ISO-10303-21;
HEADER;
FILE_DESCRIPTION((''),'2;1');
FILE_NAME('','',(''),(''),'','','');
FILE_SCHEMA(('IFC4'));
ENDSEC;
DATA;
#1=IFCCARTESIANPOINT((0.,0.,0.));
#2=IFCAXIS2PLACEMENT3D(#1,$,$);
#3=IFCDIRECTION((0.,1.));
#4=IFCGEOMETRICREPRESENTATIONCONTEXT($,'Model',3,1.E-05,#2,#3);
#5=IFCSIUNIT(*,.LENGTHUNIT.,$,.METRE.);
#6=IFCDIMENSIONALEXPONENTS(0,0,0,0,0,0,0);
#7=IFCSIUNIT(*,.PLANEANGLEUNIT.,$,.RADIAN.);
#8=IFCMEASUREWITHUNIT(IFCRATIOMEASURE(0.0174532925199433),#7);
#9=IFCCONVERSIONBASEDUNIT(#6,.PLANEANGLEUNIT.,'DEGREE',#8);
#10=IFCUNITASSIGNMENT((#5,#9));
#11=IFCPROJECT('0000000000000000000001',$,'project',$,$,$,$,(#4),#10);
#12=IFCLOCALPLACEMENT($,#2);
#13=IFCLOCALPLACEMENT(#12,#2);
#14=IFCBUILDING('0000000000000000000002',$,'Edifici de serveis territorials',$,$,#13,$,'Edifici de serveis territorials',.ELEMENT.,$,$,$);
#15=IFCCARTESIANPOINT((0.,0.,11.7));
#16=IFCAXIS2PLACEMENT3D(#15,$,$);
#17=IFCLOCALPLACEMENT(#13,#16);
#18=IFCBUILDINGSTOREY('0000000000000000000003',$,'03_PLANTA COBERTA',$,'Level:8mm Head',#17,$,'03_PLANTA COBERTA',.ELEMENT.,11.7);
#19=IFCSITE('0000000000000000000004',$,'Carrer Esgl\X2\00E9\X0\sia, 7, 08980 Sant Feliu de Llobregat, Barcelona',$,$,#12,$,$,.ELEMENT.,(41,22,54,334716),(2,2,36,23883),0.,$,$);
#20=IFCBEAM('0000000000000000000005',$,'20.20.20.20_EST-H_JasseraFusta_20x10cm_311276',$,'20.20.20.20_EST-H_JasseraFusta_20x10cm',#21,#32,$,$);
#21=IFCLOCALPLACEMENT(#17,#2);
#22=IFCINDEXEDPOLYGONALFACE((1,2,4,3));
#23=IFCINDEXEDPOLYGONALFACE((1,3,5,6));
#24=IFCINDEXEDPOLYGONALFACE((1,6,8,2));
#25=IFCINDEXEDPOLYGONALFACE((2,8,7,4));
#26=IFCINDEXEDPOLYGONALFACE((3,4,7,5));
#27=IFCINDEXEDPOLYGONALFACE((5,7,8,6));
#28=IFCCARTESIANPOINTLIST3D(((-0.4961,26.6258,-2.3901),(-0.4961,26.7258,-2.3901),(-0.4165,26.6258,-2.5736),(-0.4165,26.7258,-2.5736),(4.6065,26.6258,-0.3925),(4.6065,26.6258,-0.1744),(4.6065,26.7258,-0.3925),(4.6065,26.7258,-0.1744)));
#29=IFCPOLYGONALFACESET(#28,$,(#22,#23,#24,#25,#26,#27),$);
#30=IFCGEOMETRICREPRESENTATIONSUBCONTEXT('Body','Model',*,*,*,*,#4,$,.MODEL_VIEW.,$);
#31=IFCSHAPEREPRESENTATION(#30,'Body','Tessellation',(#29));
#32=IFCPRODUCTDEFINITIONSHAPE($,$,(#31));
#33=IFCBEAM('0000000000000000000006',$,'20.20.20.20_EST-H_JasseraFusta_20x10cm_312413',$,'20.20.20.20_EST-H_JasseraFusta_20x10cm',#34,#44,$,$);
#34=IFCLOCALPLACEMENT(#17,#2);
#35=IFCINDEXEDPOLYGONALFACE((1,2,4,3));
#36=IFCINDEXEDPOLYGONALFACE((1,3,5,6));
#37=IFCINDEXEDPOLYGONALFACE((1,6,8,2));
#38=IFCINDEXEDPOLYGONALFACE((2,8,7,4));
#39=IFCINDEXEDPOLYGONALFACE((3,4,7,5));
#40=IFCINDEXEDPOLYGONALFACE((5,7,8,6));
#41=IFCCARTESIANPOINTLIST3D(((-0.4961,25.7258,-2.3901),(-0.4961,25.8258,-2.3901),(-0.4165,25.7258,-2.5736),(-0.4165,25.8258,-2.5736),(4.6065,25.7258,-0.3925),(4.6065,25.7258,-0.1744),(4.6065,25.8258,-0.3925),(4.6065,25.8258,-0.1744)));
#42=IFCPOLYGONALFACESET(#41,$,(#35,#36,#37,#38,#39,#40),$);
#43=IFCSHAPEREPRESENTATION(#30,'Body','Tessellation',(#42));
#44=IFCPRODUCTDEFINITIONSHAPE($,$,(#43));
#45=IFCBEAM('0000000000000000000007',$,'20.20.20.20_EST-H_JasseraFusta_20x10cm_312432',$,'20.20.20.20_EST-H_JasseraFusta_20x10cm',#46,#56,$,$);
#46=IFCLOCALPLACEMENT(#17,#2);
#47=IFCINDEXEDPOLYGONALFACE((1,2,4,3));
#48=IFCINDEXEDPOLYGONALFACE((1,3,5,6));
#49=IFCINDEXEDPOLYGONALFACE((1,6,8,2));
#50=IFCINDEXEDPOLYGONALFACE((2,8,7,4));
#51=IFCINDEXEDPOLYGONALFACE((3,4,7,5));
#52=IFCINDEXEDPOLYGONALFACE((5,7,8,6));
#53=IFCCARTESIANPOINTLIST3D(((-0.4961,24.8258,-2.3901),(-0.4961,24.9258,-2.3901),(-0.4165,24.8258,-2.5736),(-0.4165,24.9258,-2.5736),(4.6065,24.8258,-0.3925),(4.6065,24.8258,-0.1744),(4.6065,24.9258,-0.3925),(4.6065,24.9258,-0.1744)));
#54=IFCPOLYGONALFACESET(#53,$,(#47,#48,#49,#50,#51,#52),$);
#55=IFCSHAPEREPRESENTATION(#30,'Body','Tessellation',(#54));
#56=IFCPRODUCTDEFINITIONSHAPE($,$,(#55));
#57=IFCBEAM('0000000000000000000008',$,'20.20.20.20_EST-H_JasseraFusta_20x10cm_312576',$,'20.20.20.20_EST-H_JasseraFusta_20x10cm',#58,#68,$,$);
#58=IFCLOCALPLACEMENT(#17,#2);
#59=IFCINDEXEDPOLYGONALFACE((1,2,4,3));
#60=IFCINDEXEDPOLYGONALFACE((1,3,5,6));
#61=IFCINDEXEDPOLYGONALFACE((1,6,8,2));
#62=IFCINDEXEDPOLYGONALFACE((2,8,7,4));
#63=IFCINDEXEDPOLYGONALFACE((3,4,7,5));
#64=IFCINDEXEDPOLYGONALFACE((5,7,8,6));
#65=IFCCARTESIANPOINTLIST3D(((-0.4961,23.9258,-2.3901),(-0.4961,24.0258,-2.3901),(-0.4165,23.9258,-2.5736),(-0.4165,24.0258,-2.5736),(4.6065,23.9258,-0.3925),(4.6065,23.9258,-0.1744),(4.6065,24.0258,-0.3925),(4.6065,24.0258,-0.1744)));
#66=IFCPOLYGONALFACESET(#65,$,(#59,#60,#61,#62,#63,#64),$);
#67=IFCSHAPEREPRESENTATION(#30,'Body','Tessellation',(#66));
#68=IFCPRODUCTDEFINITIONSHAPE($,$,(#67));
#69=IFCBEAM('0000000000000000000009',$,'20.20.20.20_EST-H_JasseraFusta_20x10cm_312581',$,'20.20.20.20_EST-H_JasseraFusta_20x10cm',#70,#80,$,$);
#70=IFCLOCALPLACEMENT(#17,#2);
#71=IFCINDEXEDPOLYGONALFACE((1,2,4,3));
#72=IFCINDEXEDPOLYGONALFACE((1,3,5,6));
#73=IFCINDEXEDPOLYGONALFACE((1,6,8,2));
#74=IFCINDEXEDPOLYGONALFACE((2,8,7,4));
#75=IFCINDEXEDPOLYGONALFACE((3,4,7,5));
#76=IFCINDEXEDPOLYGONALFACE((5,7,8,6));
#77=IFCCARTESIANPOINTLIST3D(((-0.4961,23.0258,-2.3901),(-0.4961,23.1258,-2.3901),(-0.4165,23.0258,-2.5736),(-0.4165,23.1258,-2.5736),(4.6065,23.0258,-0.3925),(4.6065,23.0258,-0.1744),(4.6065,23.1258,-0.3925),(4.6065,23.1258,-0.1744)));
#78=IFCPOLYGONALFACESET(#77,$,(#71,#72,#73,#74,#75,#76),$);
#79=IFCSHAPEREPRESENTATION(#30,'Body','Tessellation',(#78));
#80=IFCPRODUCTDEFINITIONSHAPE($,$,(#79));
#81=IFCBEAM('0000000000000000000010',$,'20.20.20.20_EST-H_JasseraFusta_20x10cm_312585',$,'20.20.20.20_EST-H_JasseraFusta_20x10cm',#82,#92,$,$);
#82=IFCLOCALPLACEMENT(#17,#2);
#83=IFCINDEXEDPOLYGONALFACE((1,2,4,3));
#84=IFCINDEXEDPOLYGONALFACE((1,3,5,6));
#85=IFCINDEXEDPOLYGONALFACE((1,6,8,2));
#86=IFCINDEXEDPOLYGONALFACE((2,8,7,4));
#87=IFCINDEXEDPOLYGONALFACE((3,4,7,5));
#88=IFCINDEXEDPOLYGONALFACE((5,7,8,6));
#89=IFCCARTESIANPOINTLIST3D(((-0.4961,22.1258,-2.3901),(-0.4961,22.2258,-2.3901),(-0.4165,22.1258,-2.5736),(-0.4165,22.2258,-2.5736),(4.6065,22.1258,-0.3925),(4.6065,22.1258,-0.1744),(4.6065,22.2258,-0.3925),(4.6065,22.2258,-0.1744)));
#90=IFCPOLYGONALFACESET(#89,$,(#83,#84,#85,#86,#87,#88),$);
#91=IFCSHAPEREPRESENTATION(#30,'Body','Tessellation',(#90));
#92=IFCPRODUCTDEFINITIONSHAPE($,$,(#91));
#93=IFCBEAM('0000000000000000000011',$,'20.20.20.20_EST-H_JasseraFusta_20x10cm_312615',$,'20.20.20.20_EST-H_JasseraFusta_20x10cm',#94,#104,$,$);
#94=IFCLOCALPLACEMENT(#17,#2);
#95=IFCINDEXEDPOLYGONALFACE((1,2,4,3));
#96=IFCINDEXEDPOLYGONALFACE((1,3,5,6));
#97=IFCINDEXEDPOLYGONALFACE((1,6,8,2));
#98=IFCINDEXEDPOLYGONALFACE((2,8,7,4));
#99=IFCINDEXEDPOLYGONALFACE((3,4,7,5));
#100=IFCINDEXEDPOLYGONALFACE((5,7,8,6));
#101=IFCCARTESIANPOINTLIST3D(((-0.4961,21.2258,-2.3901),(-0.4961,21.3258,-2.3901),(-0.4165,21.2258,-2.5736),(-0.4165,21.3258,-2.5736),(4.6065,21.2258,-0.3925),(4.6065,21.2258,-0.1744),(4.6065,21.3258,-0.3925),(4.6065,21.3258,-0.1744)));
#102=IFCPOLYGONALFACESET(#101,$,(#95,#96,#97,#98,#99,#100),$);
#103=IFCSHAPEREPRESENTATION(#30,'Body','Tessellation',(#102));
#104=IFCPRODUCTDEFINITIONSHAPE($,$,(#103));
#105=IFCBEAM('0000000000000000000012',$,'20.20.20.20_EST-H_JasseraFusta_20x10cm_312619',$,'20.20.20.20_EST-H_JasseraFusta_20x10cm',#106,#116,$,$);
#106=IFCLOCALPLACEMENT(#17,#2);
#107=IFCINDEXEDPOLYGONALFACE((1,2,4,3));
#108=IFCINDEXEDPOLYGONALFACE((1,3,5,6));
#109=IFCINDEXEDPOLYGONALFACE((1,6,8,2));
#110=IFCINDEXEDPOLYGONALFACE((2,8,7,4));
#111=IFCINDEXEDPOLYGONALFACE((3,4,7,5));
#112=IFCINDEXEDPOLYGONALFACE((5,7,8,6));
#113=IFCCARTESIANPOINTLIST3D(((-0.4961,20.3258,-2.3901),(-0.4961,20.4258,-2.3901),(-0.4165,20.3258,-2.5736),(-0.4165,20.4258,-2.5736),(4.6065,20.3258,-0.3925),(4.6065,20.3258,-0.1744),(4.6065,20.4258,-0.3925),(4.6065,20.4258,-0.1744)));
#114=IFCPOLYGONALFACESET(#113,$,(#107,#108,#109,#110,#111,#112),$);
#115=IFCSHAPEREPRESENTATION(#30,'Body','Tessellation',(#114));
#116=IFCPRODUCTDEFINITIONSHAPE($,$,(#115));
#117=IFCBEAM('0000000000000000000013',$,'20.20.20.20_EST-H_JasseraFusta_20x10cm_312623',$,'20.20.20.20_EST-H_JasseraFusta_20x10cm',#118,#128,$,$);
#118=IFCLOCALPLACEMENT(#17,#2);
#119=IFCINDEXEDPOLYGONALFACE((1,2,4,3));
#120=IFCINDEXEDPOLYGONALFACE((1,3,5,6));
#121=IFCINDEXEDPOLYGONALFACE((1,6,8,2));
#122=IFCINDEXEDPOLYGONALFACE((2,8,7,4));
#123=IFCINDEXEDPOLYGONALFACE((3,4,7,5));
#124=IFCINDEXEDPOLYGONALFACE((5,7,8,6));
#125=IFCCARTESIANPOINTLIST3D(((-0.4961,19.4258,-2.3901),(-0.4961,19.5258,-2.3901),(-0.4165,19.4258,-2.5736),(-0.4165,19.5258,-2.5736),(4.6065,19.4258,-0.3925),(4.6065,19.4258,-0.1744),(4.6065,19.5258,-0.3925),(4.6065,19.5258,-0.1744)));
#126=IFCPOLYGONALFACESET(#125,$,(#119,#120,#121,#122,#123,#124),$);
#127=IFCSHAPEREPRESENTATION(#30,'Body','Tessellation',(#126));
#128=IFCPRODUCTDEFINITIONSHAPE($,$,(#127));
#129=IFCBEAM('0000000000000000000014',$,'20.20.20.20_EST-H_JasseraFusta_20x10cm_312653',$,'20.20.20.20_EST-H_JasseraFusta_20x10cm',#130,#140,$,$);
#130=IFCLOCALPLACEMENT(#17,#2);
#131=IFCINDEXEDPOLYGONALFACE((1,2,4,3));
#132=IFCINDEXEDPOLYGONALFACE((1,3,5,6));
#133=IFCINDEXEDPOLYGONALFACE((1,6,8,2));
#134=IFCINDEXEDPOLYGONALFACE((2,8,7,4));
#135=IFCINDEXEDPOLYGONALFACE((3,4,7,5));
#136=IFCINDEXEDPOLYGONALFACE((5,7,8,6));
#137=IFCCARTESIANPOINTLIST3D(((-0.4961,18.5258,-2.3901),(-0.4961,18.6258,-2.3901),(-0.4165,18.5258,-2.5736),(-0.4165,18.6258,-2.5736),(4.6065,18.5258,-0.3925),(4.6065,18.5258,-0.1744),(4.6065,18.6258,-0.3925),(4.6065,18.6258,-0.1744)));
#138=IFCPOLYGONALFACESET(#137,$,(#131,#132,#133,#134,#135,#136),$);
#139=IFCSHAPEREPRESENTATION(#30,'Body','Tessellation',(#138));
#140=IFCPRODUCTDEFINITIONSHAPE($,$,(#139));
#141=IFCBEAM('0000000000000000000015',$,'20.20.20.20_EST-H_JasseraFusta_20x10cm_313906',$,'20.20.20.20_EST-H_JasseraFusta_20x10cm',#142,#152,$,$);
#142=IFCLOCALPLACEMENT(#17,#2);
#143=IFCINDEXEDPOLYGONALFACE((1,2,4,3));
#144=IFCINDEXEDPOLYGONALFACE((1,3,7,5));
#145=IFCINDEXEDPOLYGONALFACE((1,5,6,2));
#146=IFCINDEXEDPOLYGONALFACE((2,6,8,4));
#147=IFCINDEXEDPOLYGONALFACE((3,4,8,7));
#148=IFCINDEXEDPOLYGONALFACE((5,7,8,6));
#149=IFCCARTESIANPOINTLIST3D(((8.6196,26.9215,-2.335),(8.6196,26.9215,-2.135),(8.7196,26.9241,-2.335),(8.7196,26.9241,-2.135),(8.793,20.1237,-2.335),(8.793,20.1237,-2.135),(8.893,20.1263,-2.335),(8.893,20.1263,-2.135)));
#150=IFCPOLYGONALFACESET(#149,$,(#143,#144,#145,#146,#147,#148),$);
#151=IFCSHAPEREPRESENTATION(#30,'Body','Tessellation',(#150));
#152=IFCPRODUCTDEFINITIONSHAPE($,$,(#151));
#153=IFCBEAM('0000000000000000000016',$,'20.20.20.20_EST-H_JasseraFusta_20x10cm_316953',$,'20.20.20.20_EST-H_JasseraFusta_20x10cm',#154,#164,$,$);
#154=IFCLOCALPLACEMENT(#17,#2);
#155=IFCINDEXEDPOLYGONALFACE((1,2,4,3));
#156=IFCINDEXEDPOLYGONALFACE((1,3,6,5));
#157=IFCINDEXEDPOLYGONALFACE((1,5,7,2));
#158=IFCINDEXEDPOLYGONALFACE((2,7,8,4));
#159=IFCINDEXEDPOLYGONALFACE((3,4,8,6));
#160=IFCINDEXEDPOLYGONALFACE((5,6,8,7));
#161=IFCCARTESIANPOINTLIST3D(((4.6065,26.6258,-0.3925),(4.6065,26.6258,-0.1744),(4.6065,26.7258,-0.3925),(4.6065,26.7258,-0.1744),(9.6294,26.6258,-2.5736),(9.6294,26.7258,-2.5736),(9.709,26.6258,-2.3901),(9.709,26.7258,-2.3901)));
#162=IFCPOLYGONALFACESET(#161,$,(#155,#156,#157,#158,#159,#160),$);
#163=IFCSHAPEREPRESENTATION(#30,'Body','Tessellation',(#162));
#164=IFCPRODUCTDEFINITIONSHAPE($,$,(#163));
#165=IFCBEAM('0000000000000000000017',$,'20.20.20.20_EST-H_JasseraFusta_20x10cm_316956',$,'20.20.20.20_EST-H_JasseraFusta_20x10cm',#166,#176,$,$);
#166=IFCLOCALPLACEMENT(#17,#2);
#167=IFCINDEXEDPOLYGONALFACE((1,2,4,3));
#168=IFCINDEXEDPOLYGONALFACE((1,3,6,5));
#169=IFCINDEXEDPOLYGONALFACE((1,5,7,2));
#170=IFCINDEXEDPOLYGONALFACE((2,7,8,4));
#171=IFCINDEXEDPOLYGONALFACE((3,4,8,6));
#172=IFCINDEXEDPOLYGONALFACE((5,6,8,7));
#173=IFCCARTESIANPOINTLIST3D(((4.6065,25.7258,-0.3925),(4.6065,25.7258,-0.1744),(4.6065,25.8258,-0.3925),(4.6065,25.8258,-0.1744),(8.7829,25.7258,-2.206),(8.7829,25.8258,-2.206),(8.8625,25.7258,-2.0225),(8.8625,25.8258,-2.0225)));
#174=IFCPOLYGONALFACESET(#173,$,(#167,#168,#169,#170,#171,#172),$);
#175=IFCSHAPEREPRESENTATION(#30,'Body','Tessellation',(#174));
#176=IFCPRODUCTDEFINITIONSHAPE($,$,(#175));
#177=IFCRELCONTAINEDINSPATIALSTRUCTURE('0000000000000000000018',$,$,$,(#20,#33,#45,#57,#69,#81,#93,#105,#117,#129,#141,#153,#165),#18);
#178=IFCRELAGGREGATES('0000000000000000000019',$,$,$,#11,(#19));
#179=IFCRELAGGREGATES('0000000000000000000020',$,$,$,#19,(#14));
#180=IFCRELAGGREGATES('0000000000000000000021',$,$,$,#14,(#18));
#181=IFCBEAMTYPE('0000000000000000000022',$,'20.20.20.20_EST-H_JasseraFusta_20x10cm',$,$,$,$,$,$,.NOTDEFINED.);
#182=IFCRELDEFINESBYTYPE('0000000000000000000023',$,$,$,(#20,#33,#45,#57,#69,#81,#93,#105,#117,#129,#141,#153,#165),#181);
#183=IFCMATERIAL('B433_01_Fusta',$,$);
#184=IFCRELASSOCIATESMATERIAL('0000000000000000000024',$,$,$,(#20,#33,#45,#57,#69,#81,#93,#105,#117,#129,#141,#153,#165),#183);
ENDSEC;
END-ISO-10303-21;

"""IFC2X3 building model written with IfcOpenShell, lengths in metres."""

from ifc_helpers import new_model, entity, si_unit, converted_unit, direction, frame, frame_2d, origin, origin_2d_with_axis, place, context, subcontext, project, spatial, rectangle, extrude, clip, halfspace, material, type_object, element, save


model = new_model("IFC2X3")

# Units and contexts
model_context = context("Model", 3, precision=1e-05, world=origin(), true_north=direction((0.0, 1.0)))
body_context = subcontext(model_context, "Body", "Model", "MODEL_VIEW")
ifc_project = project(units=[si_unit("LENGTHUNIT", "METRE"), converted_unit("PLANEANGLEUNIT", "DEGREE", entity("IfcRatioMeasure", 0.0174532925199433), si_unit("PLANEANGLEUNIT", "RADIAN"), dimensions=[0, 0, 0, 0, 0, 0, 0])], contexts=[model_context])

# Site, building, storey
site_placement = place(None, origin())
site = spatial("IfcSite", under=ifc_project, at=site_placement, Name="Carrer Església, 7, 08980 Sant Feliu de Llobregat, Barcelona", CompositionType="ELEMENT", RefLatitude=(41, 22, 54, 334716), RefLongitude=(2, 2, 36, 23883), RefElevation=0.0)
building_placement = place(site_placement, origin())
building = spatial("IfcBuilding", under=site, at=building_placement, Name="Edifici de serveis territorials", LongName="Edifici de serveis territorials", CompositionType="ELEMENT")
storey_placement = place(building_placement, frame((0.0, 0.0, 11.7)))
storey = spatial("IfcBuildingStorey", under=building, at=storey_placement, Name="03_PLANTA COBERTA", ObjectType="Level:8mm Head", LongName="03_PLANTA COBERTA", CompositionType="ELEMENT", Elevation=11.7)

# Beams
ifc_material_1 = material(Name="B433_01_Fusta")
beam_type = type_object("IfcBeamType", Name="20.20.20.20_EST-H_JasseraFusta_20x10cm", PredefinedType="NOTDEFINED")
beam_1_placement = place(storey_placement, frame((4.6065, 26.6758, -0.1744), z_axis=(-0.3983, 0.0, 0.917255), x_axis=(-0.917255, 0.0, -0.3983)))
element("IfcBeam", 1, at=beam_1_placement, inside=storey, type_object=beam_type, material=ifc_material_1, Name="20.20.20.20_EST-H_JasseraFusta_20x10cm_311276", ObjectType="20.20.20.20_EST-H_JasseraFusta_20x10cm", context=body_context, shape_type="Clipping", body=[
    clip(extrude(rectangle(XDim=0.2, YDim=0.1, at=frame_2d((0.0, 0.0), x_axis=(1.0, 0.0))), frame((0.0, 0.0, -0.1), z_axis=(1.0, 0.0, 0.0), x_axis=(0.0, 0.0, -1.0)), (0.0, 0.0, 1.0), 5.5629), halfspace(frame((0.0868, 0.0, -0.2), z_axis=(-0.917255, 0.0, -0.3983), x_axis=(0.0, 1.0, 0.0)), False)),
])
beam_2_placement = place(storey_placement, frame((4.6065, 25.7758, -0.1744), z_axis=(-0.3983, 0.0, 0.917255), x_axis=(-0.917255, 0.0, -0.3983)))
element("IfcBeam", 2, at=beam_2_placement, inside=storey, type_object=beam_type, material=ifc_material_1, Name="20.20.20.20_EST-H_JasseraFusta_20x10cm_312413", ObjectType="20.20.20.20_EST-H_JasseraFusta_20x10cm", context=body_context, shape_type="Clipping", body=[
    clip(extrude(rectangle(XDim=0.2, YDim=0.1, at=frame_2d((0.0, 0.0), x_axis=(1.0, 0.0))), frame((0.0, 0.0, -0.1), z_axis=(1.0, 0.0, 0.0), x_axis=(0.0, 0.0, -1.0)), (0.0, 0.0, 1.0), 5.5629), halfspace(frame((0.0868, 0.0, -0.2), z_axis=(-0.917255, 0.0, -0.3983), x_axis=(0.0, 1.0, 0.0)), False)),
])
beam_3_placement = place(storey_placement, frame((4.6065, 24.8758, -0.1744), z_axis=(-0.3983, 0.0, 0.917255), x_axis=(-0.917255, 0.0, -0.3983)))
element("IfcBeam", 3, at=beam_3_placement, inside=storey, type_object=beam_type, material=ifc_material_1, Name="20.20.20.20_EST-H_JasseraFusta_20x10cm_312432", ObjectType="20.20.20.20_EST-H_JasseraFusta_20x10cm", context=body_context, shape_type="Clipping", body=[
    clip(extrude(rectangle(XDim=0.2, YDim=0.1, at=frame_2d((0.0, 0.0), x_axis=(1.0, 0.0))), frame((0.0, 0.0, -0.1), z_axis=(1.0, 0.0, 0.0), x_axis=(0.0, 0.0, -1.0)), (0.0, 0.0, 1.0), 5.5629), halfspace(frame((0.0868, 0.0, -0.2), z_axis=(-0.917255, 0.0, -0.3983), x_axis=(0.0, 1.0, 0.0)), False)),
])
beam_4_placement = place(storey_placement, frame((4.6065, 23.9758, -0.1744), z_axis=(-0.3983, 0.0, 0.917255), x_axis=(-0.917255, 0.0, -0.3983)))
element("IfcBeam", 4, at=beam_4_placement, inside=storey, type_object=beam_type, material=ifc_material_1, Name="20.20.20.20_EST-H_JasseraFusta_20x10cm_312576", ObjectType="20.20.20.20_EST-H_JasseraFusta_20x10cm", context=body_context, shape_type="Clipping", body=[
    clip(extrude(rectangle(XDim=0.2, YDim=0.1, at=frame_2d((0.0, 0.0), x_axis=(1.0, 0.0))), frame((0.0, 0.0, -0.1), z_axis=(1.0, 0.0, 0.0), x_axis=(0.0, 0.0, -1.0)), (0.0, 0.0, 1.0), 5.5629), halfspace(frame((0.0868, 0.0, -0.2), z_axis=(-0.917255, 0.0, -0.3983), x_axis=(0.0, 1.0, 0.0)), False)),
])
beam_5_placement = place(storey_placement, frame((4.6065, 23.0758, -0.1744), z_axis=(-0.3983, 0.0, 0.917255), x_axis=(-0.917255, 0.0, -0.3983)))
element("IfcBeam", 5, at=beam_5_placement, inside=storey, type_object=beam_type, material=ifc_material_1, Name="20.20.20.20_EST-H_JasseraFusta_20x10cm_312581", ObjectType="20.20.20.20_EST-H_JasseraFusta_20x10cm", context=body_context, shape_type="Clipping", body=[
    clip(extrude(rectangle(XDim=0.2, YDim=0.1, at=frame_2d((0.0, 0.0), x_axis=(1.0, 0.0))), frame((0.0, 0.0, -0.1), z_axis=(1.0, 0.0, 0.0), x_axis=(0.0, 0.0, -1.0)), (0.0, 0.0, 1.0), 5.5629), halfspace(frame((0.0868, 0.0, -0.2), z_axis=(-0.917255, 0.0, -0.3983), x_axis=(0.0, 1.0, 0.0)), False)),
])
beam_6_placement = place(storey_placement, frame((4.6065, 22.1758, -0.1744), z_axis=(-0.3983, 0.0, 0.917255), x_axis=(-0.917255, 0.0, -0.3983)))
element("IfcBeam", 6, at=beam_6_placement, inside=storey, type_object=beam_type, material=ifc_material_1, Name="20.20.20.20_EST-H_JasseraFusta_20x10cm_312585", ObjectType="20.20.20.20_EST-H_JasseraFusta_20x10cm", context=body_context, shape_type="Clipping", body=[
    clip(extrude(rectangle(XDim=0.2, YDim=0.1, at=frame_2d((0.0, 0.0), x_axis=(1.0, 0.0))), frame((0.0, 0.0, -0.1), z_axis=(1.0, 0.0, 0.0), x_axis=(0.0, 0.0, -1.0)), (0.0, 0.0, 1.0), 5.5629), halfspace(frame((0.0868, 0.0, -0.2), z_axis=(-0.917255, 0.0, -0.3983), x_axis=(0.0, 1.0, 0.0)), False)),
])
beam_7_placement = place(storey_placement, frame((4.6065, 21.2758, -0.1744), z_axis=(-0.3983, 0.0, 0.917255), x_axis=(-0.917255, 0.0, -0.3983)))
element("IfcBeam", 7, at=beam_7_placement, inside=storey, type_object=beam_type, material=ifc_material_1, Name="20.20.20.20_EST-H_JasseraFusta_20x10cm_312615", ObjectType="20.20.20.20_EST-H_JasseraFusta_20x10cm", context=body_context, shape_type="Clipping", body=[
    clip(extrude(rectangle(XDim=0.2, YDim=0.1, at=frame_2d((0.0, 0.0), x_axis=(1.0, 0.0))), frame((0.0, 0.0, -0.1), z_axis=(1.0, 0.0, 0.0), x_axis=(0.0, 0.0, -1.0)), (0.0, 0.0, 1.0), 5.5629), halfspace(frame((0.0868, 0.0, -0.2), z_axis=(-0.917255, 0.0, -0.3983), x_axis=(0.0, 1.0, 0.0)), False)),
])
beam_8_placement = place(storey_placement, frame((4.6065, 20.3758, -0.1744), z_axis=(-0.3983, 0.0, 0.917255), x_axis=(-0.917255, 0.0, -0.3983)))
element("IfcBeam", 8, at=beam_8_placement, inside=storey, type_object=beam_type, material=ifc_material_1, Name="20.20.20.20_EST-H_JasseraFusta_20x10cm_312619", ObjectType="20.20.20.20_EST-H_JasseraFusta_20x10cm", context=body_context, shape_type="Clipping", body=[
    clip(extrude(rectangle(XDim=0.2, YDim=0.1, at=frame_2d((0.0, 0.0), x_axis=(1.0, 0.0))), frame((0.0, 0.0, -0.1), z_axis=(1.0, 0.0, 0.0), x_axis=(0.0, 0.0, -1.0)), (0.0, 0.0, 1.0), 5.5629), halfspace(frame((0.0868, 0.0, -0.2), z_axis=(-0.917255, 0.0, -0.3983), x_axis=(0.0, 1.0, 0.0)), False)),
])
beam_9_placement = place(storey_placement, frame((4.6065, 19.4758, -0.1744), z_axis=(-0.3983, 0.0, 0.917255), x_axis=(-0.917255, 0.0, -0.3983)))
element("IfcBeam", 9, at=beam_9_placement, inside=storey, type_object=beam_type, material=ifc_material_1, Name="20.20.20.20_EST-H_JasseraFusta_20x10cm_312623", ObjectType="20.20.20.20_EST-H_JasseraFusta_20x10cm", context=body_context, shape_type="Clipping", body=[
    clip(extrude(rectangle(XDim=0.2, YDim=0.1, at=frame_2d((0.0, 0.0), x_axis=(1.0, 0.0))), frame((0.0, 0.0, -0.1), z_axis=(1.0, 0.0, 0.0), x_axis=(0.0, 0.0, -1.0)), (0.0, 0.0, 1.0), 5.5629), halfspace(frame((0.0868, 0.0, -0.2), z_axis=(-0.917255, 0.0, -0.3983), x_axis=(0.0, 1.0, 0.0)), False)),
])
beam_10_placement = place(storey_placement, frame((4.6065, 18.5758, -0.1744), z_axis=(-0.3983, 0.0, 0.917255), x_axis=(-0.917255, 0.0, -0.3983)))
element("IfcBeam", 10, at=beam_10_placement, inside=storey, type_object=beam_type, material=ifc_material_1, Name="20.20.20.20_EST-H_JasseraFusta_20x10cm_312653", ObjectType="20.20.20.20_EST-H_JasseraFusta_20x10cm", context=body_context, shape_type="Clipping", body=[
    clip(extrude(rectangle(XDim=0.2, YDim=0.1, at=frame_2d((0.0, 0.0), x_axis=(1.0, 0.0))), frame((0.0, 0.0, -0.1), z_axis=(1.0, 0.0, 0.0), x_axis=(0.0, 0.0, -1.0)), (0.0, 0.0, 1.0), 5.5629), halfspace(frame((0.0868, 0.0, -0.2), z_axis=(-0.917255, 0.0, -0.3983), x_axis=(0.0, 1.0, 0.0)), False)),
])
beam_11_placement = place(storey_placement, frame((8.843, 20.125, -2.0), z_axis=(0.0, 0.0, 1.0), x_axis=(-0.025497, 0.999675, 0.0)))
element("IfcBeam", 11, at=beam_11_placement, inside=storey, type_object=beam_type, material=ifc_material_1, Name="20.20.20.20_EST-H_JasseraFusta_20x10cm_313906", ObjectType="20.20.20.20_EST-H_JasseraFusta_20x10cm", context=body_context, shape_type="SweptSolid", body=[
    extrude(rectangle(XDim=0.2, YDim=0.1, at=frame_2d((0.0, 0.0), x_axis=(1.0, 0.0))), frame((0.0, 0.0, -0.235), z_axis=(1.0, 0.0, 0.0), x_axis=(0.0, 0.0, -1.0)), (0.0, 0.0, 1.0), 6.8),
])
beam_12_placement = place(storey_placement, frame((4.6065, 26.6758, -0.1744), z_axis=(0.3983, 0.0, 0.917255), x_axis=(0.917255, 0.0, -0.3983)))
element("IfcBeam", 12, at=beam_12_placement, inside=storey, type_object=beam_type, material=ifc_material_1, Name="20.20.20.20_EST-H_JasseraFusta_20x10cm_316953", ObjectType="20.20.20.20_EST-H_JasseraFusta_20x10cm", context=body_context, shape_type="Clipping", body=[
    clip(extrude(rectangle(XDim=0.2, YDim=0.1, at=origin_2d_with_axis()), frame((0.0, 0.0, -0.1), z_axis=(1.0, 0.0, 0.0), x_axis=(0.0, 0.0, -1.0)), (0.0, 0.0, 1.0), 5.5629), halfspace(frame((0.0868, 0.0, -0.2), z_axis=(-0.917255, 0.0, -0.3983), x_axis=(0.0, 1.0, 0.0)), False)),
])
beam_13_placement = place(storey_placement, frame((4.6065, 25.7758, -0.1744), z_axis=(0.3983, 0.0, 0.917255), x_axis=(0.917255, 0.0, -0.3983)))
element("IfcBeam", 13, at=beam_13_placement, inside=storey, type_object=beam_type, material=ifc_material_1, Name="20.20.20.20_EST-H_JasseraFusta_20x10cm_316956", ObjectType="20.20.20.20_EST-H_JasseraFusta_20x10cm", context=body_context, shape_type="Clipping", body=[
    clip(extrude(rectangle(XDim=0.2, YDim=0.1, at=frame_2d((0.0, 0.0), x_axis=(1.0, 0.0))), frame((0.0, 0.0, -0.1), z_axis=(1.0, 0.0, 0.0), x_axis=(0.0, 0.0, -1.0)), (0.0, 0.0, 1.0), 4.64), halfspace(frame((0.0868, 0.0, -0.2), z_axis=(-0.917255, 0.0, -0.3983), x_axis=(0.0, 1.0, 0.0)), False)),
])

save(model, "model.ifc")
